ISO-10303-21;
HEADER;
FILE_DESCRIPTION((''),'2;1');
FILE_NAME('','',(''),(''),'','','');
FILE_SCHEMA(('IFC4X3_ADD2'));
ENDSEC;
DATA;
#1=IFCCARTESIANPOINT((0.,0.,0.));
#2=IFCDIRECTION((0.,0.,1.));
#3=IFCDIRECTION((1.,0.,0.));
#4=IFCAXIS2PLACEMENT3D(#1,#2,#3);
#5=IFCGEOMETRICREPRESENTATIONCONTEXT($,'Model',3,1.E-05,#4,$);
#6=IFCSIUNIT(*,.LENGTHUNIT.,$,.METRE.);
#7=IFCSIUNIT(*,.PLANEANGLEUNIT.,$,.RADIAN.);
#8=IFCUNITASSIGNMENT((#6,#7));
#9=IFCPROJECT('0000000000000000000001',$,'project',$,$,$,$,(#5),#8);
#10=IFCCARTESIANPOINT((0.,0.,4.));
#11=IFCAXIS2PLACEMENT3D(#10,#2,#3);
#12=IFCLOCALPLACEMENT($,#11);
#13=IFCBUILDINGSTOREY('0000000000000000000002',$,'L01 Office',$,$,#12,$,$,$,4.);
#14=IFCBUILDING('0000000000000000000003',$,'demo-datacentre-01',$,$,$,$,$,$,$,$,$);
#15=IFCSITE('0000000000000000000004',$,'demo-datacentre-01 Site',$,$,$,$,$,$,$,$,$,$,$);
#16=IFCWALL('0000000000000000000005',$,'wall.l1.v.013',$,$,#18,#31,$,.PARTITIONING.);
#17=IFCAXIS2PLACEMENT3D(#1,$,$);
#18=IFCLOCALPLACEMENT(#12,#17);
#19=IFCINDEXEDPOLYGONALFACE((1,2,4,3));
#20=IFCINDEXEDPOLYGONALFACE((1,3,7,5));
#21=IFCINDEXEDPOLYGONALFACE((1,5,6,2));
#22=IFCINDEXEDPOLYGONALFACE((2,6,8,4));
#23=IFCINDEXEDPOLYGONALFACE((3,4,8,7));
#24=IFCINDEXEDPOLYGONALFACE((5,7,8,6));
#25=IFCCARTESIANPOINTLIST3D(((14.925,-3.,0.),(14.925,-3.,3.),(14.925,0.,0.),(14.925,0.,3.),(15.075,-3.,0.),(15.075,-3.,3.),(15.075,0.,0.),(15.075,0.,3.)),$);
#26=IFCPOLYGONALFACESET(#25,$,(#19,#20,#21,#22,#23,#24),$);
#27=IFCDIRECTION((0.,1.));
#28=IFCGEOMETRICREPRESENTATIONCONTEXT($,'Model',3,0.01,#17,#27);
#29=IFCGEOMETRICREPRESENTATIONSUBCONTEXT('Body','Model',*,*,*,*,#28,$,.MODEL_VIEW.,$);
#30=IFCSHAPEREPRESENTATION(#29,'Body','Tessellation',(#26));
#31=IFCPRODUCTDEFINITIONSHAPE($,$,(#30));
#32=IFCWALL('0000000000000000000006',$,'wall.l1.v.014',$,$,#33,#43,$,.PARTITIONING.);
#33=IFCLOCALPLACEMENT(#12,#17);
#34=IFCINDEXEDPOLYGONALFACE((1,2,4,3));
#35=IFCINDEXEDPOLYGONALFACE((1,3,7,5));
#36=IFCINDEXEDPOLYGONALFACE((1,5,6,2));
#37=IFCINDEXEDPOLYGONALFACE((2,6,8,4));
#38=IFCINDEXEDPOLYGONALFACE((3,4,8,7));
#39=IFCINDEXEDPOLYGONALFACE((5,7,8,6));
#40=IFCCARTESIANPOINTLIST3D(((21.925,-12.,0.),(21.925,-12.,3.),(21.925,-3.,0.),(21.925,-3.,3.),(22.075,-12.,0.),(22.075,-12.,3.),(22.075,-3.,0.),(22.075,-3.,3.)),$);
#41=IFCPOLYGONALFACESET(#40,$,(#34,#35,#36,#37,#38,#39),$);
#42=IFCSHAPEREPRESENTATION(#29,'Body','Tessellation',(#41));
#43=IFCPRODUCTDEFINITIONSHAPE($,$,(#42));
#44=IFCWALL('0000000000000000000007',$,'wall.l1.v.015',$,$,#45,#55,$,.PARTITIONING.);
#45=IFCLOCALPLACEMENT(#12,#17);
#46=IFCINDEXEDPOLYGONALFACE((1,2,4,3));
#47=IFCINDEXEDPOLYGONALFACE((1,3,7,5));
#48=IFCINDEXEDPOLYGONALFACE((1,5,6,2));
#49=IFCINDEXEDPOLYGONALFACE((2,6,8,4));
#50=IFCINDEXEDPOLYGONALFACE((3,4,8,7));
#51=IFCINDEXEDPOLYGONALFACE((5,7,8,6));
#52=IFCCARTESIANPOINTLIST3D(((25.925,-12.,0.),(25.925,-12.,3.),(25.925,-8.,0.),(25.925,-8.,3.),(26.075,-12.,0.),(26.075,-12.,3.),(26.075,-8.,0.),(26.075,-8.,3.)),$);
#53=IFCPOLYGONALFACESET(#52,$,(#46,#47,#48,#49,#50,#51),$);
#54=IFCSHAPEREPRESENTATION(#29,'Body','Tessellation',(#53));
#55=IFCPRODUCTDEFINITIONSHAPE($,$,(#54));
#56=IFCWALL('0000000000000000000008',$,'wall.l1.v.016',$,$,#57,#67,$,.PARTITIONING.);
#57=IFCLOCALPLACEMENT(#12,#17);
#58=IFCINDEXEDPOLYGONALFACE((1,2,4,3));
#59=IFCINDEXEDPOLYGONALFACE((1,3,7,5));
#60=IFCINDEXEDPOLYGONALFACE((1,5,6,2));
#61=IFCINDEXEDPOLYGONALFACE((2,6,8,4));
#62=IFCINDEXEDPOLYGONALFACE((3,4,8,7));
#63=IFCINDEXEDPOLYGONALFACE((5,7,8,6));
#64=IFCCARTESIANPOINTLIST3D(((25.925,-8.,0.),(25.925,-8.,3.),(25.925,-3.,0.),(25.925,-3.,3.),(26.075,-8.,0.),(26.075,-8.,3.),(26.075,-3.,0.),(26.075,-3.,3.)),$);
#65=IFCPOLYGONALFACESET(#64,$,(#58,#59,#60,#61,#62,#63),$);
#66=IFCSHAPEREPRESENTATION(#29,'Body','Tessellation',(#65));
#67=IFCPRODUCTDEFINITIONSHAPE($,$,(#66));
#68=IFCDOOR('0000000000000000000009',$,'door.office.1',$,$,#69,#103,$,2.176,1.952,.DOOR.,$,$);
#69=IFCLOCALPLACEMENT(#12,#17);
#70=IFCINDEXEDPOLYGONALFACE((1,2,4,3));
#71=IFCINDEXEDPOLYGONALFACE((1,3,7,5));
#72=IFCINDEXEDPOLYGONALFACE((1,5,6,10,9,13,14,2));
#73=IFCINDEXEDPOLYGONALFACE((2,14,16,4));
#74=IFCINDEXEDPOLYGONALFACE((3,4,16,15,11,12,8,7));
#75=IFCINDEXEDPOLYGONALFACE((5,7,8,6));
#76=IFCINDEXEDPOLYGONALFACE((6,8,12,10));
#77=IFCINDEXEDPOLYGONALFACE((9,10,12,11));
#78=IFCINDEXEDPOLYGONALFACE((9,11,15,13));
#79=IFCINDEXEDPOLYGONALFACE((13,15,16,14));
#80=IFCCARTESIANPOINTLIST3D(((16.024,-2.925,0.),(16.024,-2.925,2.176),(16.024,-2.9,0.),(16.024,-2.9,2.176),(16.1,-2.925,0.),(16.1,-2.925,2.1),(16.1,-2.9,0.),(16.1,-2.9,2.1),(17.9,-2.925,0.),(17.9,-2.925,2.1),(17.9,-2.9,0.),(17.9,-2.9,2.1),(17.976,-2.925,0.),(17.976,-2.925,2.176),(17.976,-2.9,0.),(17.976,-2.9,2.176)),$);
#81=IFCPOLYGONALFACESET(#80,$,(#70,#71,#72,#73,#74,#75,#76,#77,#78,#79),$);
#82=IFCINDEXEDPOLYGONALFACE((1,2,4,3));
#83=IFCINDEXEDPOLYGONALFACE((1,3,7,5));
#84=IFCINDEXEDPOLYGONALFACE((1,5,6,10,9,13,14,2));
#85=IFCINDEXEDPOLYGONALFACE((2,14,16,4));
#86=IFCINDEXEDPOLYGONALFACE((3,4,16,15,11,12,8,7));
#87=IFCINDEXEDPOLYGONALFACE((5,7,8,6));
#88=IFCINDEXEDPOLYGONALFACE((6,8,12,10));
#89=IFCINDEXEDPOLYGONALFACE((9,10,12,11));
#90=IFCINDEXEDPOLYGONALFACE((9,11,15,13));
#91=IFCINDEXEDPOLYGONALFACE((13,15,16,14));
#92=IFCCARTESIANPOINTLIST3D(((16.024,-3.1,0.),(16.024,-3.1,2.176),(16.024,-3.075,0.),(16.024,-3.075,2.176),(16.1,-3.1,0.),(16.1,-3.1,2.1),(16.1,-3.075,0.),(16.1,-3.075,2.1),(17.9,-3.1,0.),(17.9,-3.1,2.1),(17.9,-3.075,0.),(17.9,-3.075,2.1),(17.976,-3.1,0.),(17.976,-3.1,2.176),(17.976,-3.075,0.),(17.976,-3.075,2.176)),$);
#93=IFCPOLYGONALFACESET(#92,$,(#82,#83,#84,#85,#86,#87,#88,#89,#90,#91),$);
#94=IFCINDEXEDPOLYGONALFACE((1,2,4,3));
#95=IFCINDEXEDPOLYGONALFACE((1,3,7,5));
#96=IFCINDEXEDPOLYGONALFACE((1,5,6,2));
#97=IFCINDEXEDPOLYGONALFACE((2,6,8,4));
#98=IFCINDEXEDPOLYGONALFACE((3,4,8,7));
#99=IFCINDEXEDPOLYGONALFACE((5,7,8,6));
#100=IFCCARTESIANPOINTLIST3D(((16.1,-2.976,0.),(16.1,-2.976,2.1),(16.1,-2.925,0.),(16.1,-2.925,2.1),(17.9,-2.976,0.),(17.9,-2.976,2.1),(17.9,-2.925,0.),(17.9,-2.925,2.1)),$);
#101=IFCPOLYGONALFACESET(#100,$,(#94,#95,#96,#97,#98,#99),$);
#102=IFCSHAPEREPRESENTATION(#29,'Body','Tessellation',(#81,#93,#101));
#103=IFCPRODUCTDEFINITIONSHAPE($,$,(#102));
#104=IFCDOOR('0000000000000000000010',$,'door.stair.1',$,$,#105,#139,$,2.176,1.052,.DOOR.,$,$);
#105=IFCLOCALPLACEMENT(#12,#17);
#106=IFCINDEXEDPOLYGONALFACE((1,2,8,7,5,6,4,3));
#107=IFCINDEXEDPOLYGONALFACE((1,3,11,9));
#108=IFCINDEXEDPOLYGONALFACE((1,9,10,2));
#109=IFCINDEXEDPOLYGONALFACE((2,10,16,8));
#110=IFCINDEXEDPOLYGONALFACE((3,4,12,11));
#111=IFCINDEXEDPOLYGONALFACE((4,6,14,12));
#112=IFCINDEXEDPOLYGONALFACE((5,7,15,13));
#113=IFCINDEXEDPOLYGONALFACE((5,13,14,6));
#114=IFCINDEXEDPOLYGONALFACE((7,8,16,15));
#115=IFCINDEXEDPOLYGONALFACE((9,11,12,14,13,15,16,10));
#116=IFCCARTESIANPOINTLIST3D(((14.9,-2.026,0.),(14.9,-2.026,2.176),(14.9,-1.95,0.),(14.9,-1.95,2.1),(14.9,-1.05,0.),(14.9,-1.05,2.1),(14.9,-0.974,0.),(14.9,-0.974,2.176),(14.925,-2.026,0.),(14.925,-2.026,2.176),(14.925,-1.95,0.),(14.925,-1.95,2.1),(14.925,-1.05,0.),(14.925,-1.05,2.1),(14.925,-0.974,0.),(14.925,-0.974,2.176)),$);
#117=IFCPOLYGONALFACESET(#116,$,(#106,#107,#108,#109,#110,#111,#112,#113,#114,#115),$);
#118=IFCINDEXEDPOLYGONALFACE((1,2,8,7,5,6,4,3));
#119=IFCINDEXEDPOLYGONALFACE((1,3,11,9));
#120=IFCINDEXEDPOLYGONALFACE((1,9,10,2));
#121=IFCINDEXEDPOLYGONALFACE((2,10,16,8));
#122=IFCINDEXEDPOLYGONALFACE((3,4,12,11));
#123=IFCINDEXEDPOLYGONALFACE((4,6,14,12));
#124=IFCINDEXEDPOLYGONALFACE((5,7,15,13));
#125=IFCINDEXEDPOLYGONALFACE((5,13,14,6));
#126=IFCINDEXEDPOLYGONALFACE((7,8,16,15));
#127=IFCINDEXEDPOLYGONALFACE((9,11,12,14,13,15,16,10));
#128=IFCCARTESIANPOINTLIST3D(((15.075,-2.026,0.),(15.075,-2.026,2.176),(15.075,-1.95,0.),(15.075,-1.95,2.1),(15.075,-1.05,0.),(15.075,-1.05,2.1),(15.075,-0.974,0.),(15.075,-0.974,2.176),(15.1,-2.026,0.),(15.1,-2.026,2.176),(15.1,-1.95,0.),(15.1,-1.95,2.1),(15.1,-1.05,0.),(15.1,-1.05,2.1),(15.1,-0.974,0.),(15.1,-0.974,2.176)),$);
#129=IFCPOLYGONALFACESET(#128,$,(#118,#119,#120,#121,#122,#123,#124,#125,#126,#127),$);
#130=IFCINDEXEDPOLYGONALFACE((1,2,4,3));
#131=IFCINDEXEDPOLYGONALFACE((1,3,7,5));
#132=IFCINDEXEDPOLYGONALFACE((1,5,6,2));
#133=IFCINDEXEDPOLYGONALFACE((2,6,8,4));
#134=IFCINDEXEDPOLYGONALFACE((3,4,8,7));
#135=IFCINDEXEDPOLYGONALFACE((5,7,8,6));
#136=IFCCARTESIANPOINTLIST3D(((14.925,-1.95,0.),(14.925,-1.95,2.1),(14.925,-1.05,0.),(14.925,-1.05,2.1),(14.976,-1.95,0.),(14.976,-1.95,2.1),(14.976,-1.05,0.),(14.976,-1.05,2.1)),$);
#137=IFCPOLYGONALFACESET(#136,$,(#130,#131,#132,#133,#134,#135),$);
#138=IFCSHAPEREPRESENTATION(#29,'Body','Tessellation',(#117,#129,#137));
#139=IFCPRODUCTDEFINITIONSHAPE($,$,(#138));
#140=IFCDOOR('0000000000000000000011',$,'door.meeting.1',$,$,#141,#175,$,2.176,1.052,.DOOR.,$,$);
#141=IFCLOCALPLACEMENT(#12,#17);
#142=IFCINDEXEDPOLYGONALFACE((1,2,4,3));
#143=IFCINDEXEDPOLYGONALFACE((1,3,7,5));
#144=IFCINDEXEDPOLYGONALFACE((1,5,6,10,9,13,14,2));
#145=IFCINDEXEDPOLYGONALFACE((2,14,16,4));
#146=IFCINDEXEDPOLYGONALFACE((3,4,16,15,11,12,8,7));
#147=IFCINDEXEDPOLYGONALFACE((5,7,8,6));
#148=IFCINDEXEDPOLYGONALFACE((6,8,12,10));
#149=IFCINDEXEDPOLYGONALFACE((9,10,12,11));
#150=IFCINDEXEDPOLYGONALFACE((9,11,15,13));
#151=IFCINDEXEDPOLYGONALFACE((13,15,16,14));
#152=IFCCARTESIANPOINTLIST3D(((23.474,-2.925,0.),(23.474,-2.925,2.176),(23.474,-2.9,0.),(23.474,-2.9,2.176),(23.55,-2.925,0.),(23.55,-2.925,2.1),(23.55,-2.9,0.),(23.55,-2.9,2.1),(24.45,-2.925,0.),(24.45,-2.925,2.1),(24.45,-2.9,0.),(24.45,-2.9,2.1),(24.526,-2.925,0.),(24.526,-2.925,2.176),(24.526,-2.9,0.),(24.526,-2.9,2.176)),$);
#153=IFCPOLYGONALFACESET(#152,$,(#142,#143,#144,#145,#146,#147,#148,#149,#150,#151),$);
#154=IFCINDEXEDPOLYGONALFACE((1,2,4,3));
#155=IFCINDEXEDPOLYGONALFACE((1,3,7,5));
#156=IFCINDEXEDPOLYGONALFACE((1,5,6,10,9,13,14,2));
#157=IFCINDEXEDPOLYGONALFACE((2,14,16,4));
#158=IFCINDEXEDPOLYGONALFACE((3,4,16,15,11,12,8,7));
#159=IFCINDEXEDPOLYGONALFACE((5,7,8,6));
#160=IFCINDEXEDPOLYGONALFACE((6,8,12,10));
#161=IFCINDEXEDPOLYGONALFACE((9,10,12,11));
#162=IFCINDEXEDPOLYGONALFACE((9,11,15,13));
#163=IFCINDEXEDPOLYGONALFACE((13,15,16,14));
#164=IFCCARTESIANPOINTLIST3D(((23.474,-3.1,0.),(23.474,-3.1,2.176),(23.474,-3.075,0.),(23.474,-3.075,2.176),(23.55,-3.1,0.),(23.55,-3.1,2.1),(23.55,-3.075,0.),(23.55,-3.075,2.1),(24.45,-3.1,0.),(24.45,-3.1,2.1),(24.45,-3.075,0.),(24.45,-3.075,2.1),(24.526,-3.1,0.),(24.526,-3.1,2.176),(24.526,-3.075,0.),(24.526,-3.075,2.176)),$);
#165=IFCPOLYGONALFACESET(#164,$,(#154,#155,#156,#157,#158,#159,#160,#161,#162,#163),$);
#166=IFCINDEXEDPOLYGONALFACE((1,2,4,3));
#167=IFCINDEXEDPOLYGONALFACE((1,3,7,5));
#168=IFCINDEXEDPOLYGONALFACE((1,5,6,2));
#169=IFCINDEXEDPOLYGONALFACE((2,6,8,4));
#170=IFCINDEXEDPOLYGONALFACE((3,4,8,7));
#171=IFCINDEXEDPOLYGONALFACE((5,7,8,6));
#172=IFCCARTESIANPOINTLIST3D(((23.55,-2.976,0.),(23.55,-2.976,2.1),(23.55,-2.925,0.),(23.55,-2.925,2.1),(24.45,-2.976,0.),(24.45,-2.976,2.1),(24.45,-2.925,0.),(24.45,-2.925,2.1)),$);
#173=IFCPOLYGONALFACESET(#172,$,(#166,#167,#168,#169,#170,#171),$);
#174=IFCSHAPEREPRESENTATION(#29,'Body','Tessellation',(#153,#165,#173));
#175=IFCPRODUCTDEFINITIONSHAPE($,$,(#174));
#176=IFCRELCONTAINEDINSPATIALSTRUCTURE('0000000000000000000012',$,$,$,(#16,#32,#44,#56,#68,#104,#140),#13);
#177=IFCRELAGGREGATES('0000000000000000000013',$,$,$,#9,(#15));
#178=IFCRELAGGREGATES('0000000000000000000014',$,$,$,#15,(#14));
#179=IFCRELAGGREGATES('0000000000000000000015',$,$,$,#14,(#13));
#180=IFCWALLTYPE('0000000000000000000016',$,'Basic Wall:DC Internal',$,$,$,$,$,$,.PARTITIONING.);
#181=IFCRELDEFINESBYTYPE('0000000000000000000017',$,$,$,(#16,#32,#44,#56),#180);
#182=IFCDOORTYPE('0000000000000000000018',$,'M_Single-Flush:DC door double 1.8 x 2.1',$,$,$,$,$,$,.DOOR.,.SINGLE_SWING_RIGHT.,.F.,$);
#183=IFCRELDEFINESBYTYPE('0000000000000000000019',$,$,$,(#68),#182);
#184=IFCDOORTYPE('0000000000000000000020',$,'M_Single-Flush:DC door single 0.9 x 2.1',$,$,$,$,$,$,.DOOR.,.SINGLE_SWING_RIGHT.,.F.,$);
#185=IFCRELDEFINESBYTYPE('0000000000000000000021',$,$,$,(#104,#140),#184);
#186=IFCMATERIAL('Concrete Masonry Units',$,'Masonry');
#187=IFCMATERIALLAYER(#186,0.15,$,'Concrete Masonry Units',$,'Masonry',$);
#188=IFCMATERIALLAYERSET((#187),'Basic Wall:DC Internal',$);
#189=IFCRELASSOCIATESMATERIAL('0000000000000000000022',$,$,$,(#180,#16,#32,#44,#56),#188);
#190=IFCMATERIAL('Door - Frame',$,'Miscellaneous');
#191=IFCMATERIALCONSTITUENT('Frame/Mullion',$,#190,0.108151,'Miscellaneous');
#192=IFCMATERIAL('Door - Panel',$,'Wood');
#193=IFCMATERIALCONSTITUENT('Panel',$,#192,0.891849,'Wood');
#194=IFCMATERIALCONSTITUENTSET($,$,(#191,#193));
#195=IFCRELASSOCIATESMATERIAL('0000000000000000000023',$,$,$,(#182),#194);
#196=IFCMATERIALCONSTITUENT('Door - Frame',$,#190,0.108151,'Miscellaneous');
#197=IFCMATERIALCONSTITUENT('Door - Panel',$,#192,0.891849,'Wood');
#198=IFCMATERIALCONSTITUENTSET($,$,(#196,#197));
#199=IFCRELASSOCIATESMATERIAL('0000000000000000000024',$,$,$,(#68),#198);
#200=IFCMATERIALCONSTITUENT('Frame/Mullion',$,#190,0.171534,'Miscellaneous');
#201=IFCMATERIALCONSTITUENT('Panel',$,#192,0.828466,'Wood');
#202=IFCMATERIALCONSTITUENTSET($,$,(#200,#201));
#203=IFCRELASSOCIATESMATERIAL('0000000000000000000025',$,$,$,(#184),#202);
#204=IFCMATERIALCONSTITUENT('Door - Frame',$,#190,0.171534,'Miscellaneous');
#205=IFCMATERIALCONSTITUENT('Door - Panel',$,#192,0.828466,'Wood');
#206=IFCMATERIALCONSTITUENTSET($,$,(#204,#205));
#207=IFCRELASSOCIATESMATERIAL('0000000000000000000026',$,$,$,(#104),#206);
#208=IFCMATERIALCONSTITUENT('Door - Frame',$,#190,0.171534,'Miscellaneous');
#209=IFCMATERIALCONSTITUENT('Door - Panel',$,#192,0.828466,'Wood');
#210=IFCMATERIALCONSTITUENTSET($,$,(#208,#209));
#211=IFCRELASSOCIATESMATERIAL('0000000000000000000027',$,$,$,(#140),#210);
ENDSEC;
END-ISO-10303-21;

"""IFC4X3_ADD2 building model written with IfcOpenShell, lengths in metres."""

from ifc_helpers import new_model, si_unit, direction, frame, frame_2d, origin, origin_with_axes, place, context, subcontext, project, spatial, polyline, rectangle, outline, extrude, source, transform, mapped, material, layer, layer_set, constituent, constituent_set, type_object, type_shapes, element, save


model = new_model("IFC4X3_ADD2")

# Units and contexts
model_context_1 = context("Model", 3, precision=0.01, world=origin(), true_north=direction((0.0, 1.0)))
model_context_2 = context("Model", 3, precision=1e-05, world=origin_with_axes())
body_context = subcontext(model_context_1, "Body", "Model", "MODEL_VIEW")
ifc_project = project(units=[si_unit("LENGTHUNIT", "METRE"), si_unit("PLANEANGLEUNIT", "RADIAN")], contexts=[model_context_2])

# Site, building, storey
site = spatial("IfcSite", under=ifc_project, Name="demo-datacentre-01 Site")
building = spatial("IfcBuilding", under=site, Name="demo-datacentre-01")
storey_placement = place(None, frame((0.0, 0.0, 4.0), z_axis=(0.0, 0.0, 1.0), x_axis=(1.0, 0.0, 0.0)))
storey = spatial("IfcBuildingStorey", under=building, at=storey_placement, Name="L01 Office", Elevation=4.0)

# Shared definitions
placement_1 = place(None, origin())
placement_2 = place(placement_1, origin())
placement_3 = place(placement_2, frame((0.0, 0.0, 4.0)))

# Walls
ifc_material_1 = material(Name="Concrete Masonry Units", Category="Masonry")
ifc_layer_1 = layer(ifc_material_1, 0.15, Name="Concrete Masonry Units", Category="Masonry")
ifc_layer_set_1 = layer_set([ifc_layer_1], Name="Basic Wall:DC Internal")
wall_type_1 = type_object("IfcWallType", Name="Basic Wall:DC Internal", PredefinedType="PARTITIONING", material=ifc_layer_set_1)
wall_1_placement = place(placement_3, frame((15.0, -3.0, 0.0), z_axis=(0.0, 0.0, 1.0), x_axis=(0.0, 1.0, 0.0)))
element("IfcWall", 1, at=wall_1_placement, inside=storey, type_object=wall_type_1, material=ifc_layer_set_1, Name="wall.l1.v.013", PredefinedType="PARTITIONING", context=body_context, shape_type="SweptSolid", body=[
    extrude(rectangle(XDim=3.0, YDim=0.15, at=frame_2d((1.5, 0.0), x_axis=(-1.0, 0.0))), origin(), (0.0, 0.0, 1.0), 3.0),
])
wall_2_placement = place(placement_3, frame((22.0, -12.0, 0.0), z_axis=(0.0, 0.0, 1.0), x_axis=(0.0, 1.0, 0.0)))
element("IfcWall", 2, at=wall_2_placement, inside=storey, type_object=wall_type_1, material=ifc_layer_set_1, Name="wall.l1.v.014", PredefinedType="PARTITIONING", context=body_context, shape_type="SweptSolid", body=[
    extrude(rectangle(XDim=9.0, YDim=0.15, at=frame_2d((4.5, 0.0), x_axis=(-1.0, 0.0))), origin(), (0.0, 0.0, 1.0), 3.0),
])
wall_3_placement = place(placement_3, frame((26.0, -12.0, 0.0), z_axis=(0.0, 0.0, 1.0), x_axis=(0.0, 1.0, 0.0)))
element("IfcWall", 3, at=wall_3_placement, inside=storey, type_object=wall_type_1, material=ifc_layer_set_1, Name="wall.l1.v.015", PredefinedType="PARTITIONING", context=body_context, shape_type="SweptSolid", body=[
    extrude(rectangle(XDim=4.0, YDim=0.15, at=frame_2d((2.0, 0.0), x_axis=(-1.0, 0.0))), origin(), (0.0, 0.0, 1.0), 3.0),
])
wall_4_placement = place(placement_3, frame((26.0, -8.0, 0.0), z_axis=(0.0, 0.0, 1.0), x_axis=(0.0, 1.0, 0.0)))
element("IfcWall", 4, at=wall_4_placement, inside=storey, type_object=wall_type_1, material=ifc_layer_set_1, Name="wall.l1.v.016", PredefinedType="PARTITIONING", context=body_context, shape_type="SweptSolid", body=[
    extrude(rectangle(XDim=5.0, YDim=0.15, at=frame_2d((2.5, 0.0), x_axis=(-1.0, 0.0))), origin(), (0.0, 0.0, 1.0), 3.0),
])

# Doors
ifc_material_2 = material(Name="Door - Frame", Category="Miscellaneous")
ifc_constituent_1 = constituent(ifc_material_2, Name="Door - Frame", Category="Miscellaneous", fraction=0.108151)
ifc_material_3 = material(Name="Door - Panel", Category="Wood")
ifc_constituent_2 = constituent(ifc_material_3, Name="Door - Panel", Category="Wood", fraction=0.891849)
ifc_constituent_set_1 = constituent_set(constituents=[ifc_constituent_1, ifc_constituent_2])
ifc_constituent_3 = constituent(ifc_material_2, Name="Frame/Mullion", Category="Miscellaneous", fraction=0.108151)
ifc_constituent_4 = constituent(ifc_material_3, Name="Panel", Category="Wood", fraction=0.891849)
ifc_constituent_set_2 = constituent_set(constituents=[ifc_constituent_3, ifc_constituent_4])
door_type_1 = type_object("IfcDoorType", Name="M_Single-Flush:DC door double 1.8 x 2.1", OperationType="SINGLE_SWING_RIGHT", ParameterTakesPrecedence=False, PredefinedType="DOOR", material=ifc_constituent_set_2)
shared_shape_1 = source(origin(), body_context, "Body", "SweptSolid", [
    extrude(outline(polyline([(-0.976, -1.107), (0.976, -1.107), (0.976, 1.069), (0.9, 1.069), (0.9, -1.031), (-0.9, -1.031), (-0.9, 1.069), (-0.976, 1.069), (-0.976, -1.107)])), frame((0.9, 0.15, 1.069), z_axis=(0.0, 1.0, 0.0), x_axis=(1.0, 0.0, 0.0)), (0.0, 0.0, 1.0), 0.025),
    extrude(outline(polyline([(-1.107, -0.976), (1.069, -0.976), (1.069, -0.9), (-1.031, -0.9), (-1.031, 0.9), (1.069, 0.9), (1.069, 0.976), (-1.107, 0.976), (-1.107, -0.976)])), frame((0.9, -0.025, 1.069), z_axis=(0.0, 1.0, 0.0), x_axis=(0.0, 0.0, -1.0)), (0.0, 0.0, 1.0), 0.025),
    extrude(rectangle(XDim=0.051, YDim=1.8, at=frame_2d((0.0, 0.0), x_axis=(1.0, 0.0))), frame((0.9, 0.1245, 0.0), z_axis=(0.0, 0.0, 1.0), x_axis=(0.0, 1.0, 0.0)), (0.0, 0.0, 1.0), 2.1),
])
type_shapes(door_type_1, [shared_shape_1])
door_1_placement = place(placement_3, frame((16.1, -3.075, 0.0)))
element("IfcDoor", 5, at=door_1_placement, inside=storey, type_object=door_type_1, material=ifc_constituent_set_1, Name="door.office.1", OverallHeight=2.176, OverallWidth=1.952, PredefinedType="DOOR", context=body_context, shape_type="MappedRepresentation", body=[
    mapped(shared_shape_1, transform((0.0, 0.0, 0.0), scale=1.0)),
])
ifc_constituent_5 = constituent(ifc_material_2, Name="Door - Frame", Category="Miscellaneous", fraction=0.171534)
ifc_constituent_6 = constituent(ifc_material_3, Name="Door - Panel", Category="Wood", fraction=0.828466)
ifc_constituent_set_3 = constituent_set(constituents=[ifc_constituent_5, ifc_constituent_6])
ifc_constituent_7 = constituent(ifc_material_2, Name="Frame/Mullion", Category="Miscellaneous", fraction=0.171534)
ifc_constituent_8 = constituent(ifc_material_3, Name="Panel", Category="Wood", fraction=0.828466)
ifc_constituent_set_4 = constituent_set(constituents=[ifc_constituent_7, ifc_constituent_8])
door_type_2 = type_object("IfcDoorType", Name="M_Single-Flush:DC door single 0.9 x 2.1", OperationType="SINGLE_SWING_RIGHT", ParameterTakesPrecedence=False, PredefinedType="DOOR", material=ifc_constituent_set_4)
shared_shape_2 = source(origin(), body_context, "Body", "SweptSolid", [
    extrude(outline(polyline([(-0.526, -1.107), (0.526, -1.107), (0.526, 1.069), (0.45, 1.069), (0.45, -1.031), (-0.45, -1.031), (-0.45, 1.069), (-0.526, 1.069), (-0.526, -1.107)])), frame((0.45, 0.15, 1.069), z_axis=(0.0, 1.0, 0.0), x_axis=(1.0, 0.0, 0.0)), (0.0, 0.0, 1.0), 0.025),
    extrude(outline(polyline([(-1.107, -0.526), (1.069, -0.526), (1.069, -0.45), (-1.031, -0.45), (-1.031, 0.45), (1.069, 0.45), (1.069, 0.526), (-1.107, 0.526), (-1.107, -0.526)])), frame((0.45, -0.025, 1.069), z_axis=(0.0, 1.0, 0.0), x_axis=(0.0, 0.0, -1.0)), (0.0, 0.0, 1.0), 0.025),
    extrude(rectangle(XDim=0.051, YDim=0.9, at=frame_2d((0.0, 0.0), x_axis=(1.0, 0.0))), frame((0.45, 0.1245, 0.0), z_axis=(0.0, 0.0, 1.0), x_axis=(0.0, 1.0, 0.0)), (0.0, 0.0, 1.0), 2.1),
])
type_shapes(door_type_2, [shared_shape_2])
door_2_placement = place(placement_3, frame((15.075, -1.95, 0.0), z_axis=(0.0, 0.0, 1.0), x_axis=(0.0, 1.0, 0.0)))
element("IfcDoor", 6, at=door_2_placement, inside=storey, type_object=door_type_2, material=ifc_constituent_set_3, Name="door.stair.1", OverallHeight=2.176, OverallWidth=1.052, PredefinedType="DOOR", context=body_context, shape_type="MappedRepresentation", body=[
    mapped(shared_shape_2, transform((0.0, 0.0, 0.0), scale=1.0)),
])
ifc_constituent_9 = constituent(ifc_material_2, Name="Door - Frame", Category="Miscellaneous", fraction=0.171534)
ifc_constituent_10 = constituent(ifc_material_3, Name="Door - Panel", Category="Wood", fraction=0.828466)
ifc_constituent_set_5 = constituent_set(constituents=[ifc_constituent_9, ifc_constituent_10])
door_3_placement = place(placement_3, frame((23.55, -3.075, 0.0)))
element("IfcDoor", 7, at=door_3_placement, inside=storey, type_object=door_type_2, material=ifc_constituent_set_5, Name="door.meeting.1", OverallHeight=2.176, OverallWidth=1.052, PredefinedType="DOOR", context=body_context, shape_type="MappedRepresentation", body=[
    mapped(shared_shape_2, transform((0.0, 0.0, 0.0), scale=1.0)),
])

save(model, "model.ifc")
